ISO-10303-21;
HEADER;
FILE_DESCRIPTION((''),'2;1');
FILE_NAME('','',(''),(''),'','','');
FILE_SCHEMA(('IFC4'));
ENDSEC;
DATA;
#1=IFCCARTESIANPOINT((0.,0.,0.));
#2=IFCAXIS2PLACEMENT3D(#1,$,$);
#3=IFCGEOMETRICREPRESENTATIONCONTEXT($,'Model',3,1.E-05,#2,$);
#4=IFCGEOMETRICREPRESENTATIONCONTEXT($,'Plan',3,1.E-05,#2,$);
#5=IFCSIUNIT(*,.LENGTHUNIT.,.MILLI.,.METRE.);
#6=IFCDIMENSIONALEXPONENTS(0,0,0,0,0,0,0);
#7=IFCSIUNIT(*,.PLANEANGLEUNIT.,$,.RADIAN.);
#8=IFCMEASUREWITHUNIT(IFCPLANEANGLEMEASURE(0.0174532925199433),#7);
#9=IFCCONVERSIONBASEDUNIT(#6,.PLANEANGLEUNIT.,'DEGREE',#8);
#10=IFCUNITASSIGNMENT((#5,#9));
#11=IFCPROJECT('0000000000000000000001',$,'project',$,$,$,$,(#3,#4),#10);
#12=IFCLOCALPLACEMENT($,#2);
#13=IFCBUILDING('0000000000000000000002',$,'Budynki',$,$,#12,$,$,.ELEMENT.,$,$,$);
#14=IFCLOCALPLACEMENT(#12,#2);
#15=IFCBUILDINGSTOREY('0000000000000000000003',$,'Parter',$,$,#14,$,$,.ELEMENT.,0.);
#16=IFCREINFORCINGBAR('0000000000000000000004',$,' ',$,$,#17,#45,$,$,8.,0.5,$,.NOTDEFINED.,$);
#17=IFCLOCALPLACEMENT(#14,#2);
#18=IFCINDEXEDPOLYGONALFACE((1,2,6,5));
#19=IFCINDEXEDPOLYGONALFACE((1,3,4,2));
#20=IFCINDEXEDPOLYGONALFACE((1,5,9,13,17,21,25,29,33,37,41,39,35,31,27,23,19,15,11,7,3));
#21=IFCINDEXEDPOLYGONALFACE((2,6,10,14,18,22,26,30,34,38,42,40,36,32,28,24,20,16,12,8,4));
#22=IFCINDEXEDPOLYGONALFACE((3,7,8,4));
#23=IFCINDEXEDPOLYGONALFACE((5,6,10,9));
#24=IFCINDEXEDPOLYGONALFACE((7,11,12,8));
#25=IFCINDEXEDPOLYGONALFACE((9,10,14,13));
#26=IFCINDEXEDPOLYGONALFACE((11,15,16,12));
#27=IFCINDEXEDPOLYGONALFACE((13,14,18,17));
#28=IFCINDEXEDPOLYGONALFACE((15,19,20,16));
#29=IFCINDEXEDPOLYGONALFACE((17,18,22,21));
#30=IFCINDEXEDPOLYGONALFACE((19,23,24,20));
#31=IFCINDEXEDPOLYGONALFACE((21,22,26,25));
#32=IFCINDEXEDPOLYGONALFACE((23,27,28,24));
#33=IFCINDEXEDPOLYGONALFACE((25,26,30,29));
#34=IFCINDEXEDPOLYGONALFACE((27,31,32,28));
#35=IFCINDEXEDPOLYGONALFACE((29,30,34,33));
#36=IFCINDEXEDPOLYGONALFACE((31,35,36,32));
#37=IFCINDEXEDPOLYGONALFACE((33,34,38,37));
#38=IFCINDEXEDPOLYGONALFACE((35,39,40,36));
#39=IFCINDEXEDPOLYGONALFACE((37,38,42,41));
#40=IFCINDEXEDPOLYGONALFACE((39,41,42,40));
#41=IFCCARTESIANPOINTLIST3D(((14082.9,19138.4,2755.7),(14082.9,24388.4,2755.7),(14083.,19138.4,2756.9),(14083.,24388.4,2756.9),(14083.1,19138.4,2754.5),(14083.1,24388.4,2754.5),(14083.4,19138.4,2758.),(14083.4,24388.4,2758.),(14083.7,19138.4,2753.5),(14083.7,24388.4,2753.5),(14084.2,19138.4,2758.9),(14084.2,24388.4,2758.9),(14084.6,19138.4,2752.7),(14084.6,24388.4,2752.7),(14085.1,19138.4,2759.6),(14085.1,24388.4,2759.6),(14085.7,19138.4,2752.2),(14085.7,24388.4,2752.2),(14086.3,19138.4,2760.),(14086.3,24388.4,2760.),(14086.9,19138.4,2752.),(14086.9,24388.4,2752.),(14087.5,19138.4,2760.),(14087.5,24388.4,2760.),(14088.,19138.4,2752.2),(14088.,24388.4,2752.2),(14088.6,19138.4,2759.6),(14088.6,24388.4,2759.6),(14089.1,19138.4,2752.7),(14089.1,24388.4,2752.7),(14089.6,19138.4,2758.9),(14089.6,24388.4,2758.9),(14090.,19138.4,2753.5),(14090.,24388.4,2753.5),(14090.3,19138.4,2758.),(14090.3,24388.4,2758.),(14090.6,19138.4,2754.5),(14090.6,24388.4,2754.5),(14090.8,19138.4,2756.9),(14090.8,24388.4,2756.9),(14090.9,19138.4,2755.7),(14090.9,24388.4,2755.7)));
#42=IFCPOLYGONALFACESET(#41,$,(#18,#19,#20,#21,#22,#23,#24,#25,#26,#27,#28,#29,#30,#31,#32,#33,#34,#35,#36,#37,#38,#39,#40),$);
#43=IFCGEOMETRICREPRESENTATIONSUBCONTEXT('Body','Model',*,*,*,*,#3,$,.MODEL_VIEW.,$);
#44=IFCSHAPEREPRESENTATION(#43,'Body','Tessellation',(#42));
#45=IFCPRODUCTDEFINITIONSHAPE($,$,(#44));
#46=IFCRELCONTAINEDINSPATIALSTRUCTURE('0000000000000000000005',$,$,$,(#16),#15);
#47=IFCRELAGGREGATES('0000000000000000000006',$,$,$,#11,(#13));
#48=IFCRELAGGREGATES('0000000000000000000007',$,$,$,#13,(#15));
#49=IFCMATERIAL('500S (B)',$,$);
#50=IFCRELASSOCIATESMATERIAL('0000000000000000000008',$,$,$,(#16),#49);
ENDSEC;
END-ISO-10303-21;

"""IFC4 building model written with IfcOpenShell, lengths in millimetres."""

from ifc_helpers import new_model, entity, si_unit, converted_unit, frame, origin, place, context, subcontext, project, spatial, material, element, save


model = new_model("IFC4")

# Units and contexts
model_context = context("Model", 3, precision=1e-05, world=origin())
plan_context = context("Plan", 3, precision=1e-05, world=origin())
body_context = subcontext(model_context, "Body", "Model", "MODEL_VIEW")
ifc_project = project(units=[si_unit("LENGTHUNIT", "METRE", prefix="MILLI"), converted_unit("PLANEANGLEUNIT", "DEGREE", entity("IfcPlaneAngleMeasure", 0.0174532925199433), si_unit("PLANEANGLEUNIT", "RADIAN"), dimensions=[0, 0, 0, 0, 0, 0, 0])], contexts=[model_context, plan_context])

# Building, storey
building_placement = place(None, origin())
building = spatial("IfcBuilding", under=ifc_project, at=building_placement, Name="Budynki", CompositionType="ELEMENT")
storey_placement = place(building_placement, origin())
storey = spatial("IfcBuildingStorey", under=building, at=storey_placement, Name="Parter", CompositionType="ELEMENT", Elevation=0.0)

# Reinforcing bar
ifc_material_1 = material(Name="500S (B)")
reinforcing_bar_1_placement = place(storey_placement, frame((14086.9, 24388.4, 2756.0)))
element("IfcReinforcingBar", 1, at=reinforcing_bar_1_placement, inside=storey, material=ifc_material_1, Name=" ", CrossSectionArea=0.5, NominalDiameter=8.0, PredefinedType="NOTDEFINED", context=body_context, shape_type="AdvancedSweptSolid", body=[
    entity("IfcSweptDiskSolid", entity("IfcPolyline", [entity("IfcCartesianPoint", [0.0, 0.0, 0.0]), entity("IfcCartesianPoint", [0.0, -5250.0, 0.0])]), 4.0, None, 0.0, 1.0),
])

save(model, "model.ifc")
